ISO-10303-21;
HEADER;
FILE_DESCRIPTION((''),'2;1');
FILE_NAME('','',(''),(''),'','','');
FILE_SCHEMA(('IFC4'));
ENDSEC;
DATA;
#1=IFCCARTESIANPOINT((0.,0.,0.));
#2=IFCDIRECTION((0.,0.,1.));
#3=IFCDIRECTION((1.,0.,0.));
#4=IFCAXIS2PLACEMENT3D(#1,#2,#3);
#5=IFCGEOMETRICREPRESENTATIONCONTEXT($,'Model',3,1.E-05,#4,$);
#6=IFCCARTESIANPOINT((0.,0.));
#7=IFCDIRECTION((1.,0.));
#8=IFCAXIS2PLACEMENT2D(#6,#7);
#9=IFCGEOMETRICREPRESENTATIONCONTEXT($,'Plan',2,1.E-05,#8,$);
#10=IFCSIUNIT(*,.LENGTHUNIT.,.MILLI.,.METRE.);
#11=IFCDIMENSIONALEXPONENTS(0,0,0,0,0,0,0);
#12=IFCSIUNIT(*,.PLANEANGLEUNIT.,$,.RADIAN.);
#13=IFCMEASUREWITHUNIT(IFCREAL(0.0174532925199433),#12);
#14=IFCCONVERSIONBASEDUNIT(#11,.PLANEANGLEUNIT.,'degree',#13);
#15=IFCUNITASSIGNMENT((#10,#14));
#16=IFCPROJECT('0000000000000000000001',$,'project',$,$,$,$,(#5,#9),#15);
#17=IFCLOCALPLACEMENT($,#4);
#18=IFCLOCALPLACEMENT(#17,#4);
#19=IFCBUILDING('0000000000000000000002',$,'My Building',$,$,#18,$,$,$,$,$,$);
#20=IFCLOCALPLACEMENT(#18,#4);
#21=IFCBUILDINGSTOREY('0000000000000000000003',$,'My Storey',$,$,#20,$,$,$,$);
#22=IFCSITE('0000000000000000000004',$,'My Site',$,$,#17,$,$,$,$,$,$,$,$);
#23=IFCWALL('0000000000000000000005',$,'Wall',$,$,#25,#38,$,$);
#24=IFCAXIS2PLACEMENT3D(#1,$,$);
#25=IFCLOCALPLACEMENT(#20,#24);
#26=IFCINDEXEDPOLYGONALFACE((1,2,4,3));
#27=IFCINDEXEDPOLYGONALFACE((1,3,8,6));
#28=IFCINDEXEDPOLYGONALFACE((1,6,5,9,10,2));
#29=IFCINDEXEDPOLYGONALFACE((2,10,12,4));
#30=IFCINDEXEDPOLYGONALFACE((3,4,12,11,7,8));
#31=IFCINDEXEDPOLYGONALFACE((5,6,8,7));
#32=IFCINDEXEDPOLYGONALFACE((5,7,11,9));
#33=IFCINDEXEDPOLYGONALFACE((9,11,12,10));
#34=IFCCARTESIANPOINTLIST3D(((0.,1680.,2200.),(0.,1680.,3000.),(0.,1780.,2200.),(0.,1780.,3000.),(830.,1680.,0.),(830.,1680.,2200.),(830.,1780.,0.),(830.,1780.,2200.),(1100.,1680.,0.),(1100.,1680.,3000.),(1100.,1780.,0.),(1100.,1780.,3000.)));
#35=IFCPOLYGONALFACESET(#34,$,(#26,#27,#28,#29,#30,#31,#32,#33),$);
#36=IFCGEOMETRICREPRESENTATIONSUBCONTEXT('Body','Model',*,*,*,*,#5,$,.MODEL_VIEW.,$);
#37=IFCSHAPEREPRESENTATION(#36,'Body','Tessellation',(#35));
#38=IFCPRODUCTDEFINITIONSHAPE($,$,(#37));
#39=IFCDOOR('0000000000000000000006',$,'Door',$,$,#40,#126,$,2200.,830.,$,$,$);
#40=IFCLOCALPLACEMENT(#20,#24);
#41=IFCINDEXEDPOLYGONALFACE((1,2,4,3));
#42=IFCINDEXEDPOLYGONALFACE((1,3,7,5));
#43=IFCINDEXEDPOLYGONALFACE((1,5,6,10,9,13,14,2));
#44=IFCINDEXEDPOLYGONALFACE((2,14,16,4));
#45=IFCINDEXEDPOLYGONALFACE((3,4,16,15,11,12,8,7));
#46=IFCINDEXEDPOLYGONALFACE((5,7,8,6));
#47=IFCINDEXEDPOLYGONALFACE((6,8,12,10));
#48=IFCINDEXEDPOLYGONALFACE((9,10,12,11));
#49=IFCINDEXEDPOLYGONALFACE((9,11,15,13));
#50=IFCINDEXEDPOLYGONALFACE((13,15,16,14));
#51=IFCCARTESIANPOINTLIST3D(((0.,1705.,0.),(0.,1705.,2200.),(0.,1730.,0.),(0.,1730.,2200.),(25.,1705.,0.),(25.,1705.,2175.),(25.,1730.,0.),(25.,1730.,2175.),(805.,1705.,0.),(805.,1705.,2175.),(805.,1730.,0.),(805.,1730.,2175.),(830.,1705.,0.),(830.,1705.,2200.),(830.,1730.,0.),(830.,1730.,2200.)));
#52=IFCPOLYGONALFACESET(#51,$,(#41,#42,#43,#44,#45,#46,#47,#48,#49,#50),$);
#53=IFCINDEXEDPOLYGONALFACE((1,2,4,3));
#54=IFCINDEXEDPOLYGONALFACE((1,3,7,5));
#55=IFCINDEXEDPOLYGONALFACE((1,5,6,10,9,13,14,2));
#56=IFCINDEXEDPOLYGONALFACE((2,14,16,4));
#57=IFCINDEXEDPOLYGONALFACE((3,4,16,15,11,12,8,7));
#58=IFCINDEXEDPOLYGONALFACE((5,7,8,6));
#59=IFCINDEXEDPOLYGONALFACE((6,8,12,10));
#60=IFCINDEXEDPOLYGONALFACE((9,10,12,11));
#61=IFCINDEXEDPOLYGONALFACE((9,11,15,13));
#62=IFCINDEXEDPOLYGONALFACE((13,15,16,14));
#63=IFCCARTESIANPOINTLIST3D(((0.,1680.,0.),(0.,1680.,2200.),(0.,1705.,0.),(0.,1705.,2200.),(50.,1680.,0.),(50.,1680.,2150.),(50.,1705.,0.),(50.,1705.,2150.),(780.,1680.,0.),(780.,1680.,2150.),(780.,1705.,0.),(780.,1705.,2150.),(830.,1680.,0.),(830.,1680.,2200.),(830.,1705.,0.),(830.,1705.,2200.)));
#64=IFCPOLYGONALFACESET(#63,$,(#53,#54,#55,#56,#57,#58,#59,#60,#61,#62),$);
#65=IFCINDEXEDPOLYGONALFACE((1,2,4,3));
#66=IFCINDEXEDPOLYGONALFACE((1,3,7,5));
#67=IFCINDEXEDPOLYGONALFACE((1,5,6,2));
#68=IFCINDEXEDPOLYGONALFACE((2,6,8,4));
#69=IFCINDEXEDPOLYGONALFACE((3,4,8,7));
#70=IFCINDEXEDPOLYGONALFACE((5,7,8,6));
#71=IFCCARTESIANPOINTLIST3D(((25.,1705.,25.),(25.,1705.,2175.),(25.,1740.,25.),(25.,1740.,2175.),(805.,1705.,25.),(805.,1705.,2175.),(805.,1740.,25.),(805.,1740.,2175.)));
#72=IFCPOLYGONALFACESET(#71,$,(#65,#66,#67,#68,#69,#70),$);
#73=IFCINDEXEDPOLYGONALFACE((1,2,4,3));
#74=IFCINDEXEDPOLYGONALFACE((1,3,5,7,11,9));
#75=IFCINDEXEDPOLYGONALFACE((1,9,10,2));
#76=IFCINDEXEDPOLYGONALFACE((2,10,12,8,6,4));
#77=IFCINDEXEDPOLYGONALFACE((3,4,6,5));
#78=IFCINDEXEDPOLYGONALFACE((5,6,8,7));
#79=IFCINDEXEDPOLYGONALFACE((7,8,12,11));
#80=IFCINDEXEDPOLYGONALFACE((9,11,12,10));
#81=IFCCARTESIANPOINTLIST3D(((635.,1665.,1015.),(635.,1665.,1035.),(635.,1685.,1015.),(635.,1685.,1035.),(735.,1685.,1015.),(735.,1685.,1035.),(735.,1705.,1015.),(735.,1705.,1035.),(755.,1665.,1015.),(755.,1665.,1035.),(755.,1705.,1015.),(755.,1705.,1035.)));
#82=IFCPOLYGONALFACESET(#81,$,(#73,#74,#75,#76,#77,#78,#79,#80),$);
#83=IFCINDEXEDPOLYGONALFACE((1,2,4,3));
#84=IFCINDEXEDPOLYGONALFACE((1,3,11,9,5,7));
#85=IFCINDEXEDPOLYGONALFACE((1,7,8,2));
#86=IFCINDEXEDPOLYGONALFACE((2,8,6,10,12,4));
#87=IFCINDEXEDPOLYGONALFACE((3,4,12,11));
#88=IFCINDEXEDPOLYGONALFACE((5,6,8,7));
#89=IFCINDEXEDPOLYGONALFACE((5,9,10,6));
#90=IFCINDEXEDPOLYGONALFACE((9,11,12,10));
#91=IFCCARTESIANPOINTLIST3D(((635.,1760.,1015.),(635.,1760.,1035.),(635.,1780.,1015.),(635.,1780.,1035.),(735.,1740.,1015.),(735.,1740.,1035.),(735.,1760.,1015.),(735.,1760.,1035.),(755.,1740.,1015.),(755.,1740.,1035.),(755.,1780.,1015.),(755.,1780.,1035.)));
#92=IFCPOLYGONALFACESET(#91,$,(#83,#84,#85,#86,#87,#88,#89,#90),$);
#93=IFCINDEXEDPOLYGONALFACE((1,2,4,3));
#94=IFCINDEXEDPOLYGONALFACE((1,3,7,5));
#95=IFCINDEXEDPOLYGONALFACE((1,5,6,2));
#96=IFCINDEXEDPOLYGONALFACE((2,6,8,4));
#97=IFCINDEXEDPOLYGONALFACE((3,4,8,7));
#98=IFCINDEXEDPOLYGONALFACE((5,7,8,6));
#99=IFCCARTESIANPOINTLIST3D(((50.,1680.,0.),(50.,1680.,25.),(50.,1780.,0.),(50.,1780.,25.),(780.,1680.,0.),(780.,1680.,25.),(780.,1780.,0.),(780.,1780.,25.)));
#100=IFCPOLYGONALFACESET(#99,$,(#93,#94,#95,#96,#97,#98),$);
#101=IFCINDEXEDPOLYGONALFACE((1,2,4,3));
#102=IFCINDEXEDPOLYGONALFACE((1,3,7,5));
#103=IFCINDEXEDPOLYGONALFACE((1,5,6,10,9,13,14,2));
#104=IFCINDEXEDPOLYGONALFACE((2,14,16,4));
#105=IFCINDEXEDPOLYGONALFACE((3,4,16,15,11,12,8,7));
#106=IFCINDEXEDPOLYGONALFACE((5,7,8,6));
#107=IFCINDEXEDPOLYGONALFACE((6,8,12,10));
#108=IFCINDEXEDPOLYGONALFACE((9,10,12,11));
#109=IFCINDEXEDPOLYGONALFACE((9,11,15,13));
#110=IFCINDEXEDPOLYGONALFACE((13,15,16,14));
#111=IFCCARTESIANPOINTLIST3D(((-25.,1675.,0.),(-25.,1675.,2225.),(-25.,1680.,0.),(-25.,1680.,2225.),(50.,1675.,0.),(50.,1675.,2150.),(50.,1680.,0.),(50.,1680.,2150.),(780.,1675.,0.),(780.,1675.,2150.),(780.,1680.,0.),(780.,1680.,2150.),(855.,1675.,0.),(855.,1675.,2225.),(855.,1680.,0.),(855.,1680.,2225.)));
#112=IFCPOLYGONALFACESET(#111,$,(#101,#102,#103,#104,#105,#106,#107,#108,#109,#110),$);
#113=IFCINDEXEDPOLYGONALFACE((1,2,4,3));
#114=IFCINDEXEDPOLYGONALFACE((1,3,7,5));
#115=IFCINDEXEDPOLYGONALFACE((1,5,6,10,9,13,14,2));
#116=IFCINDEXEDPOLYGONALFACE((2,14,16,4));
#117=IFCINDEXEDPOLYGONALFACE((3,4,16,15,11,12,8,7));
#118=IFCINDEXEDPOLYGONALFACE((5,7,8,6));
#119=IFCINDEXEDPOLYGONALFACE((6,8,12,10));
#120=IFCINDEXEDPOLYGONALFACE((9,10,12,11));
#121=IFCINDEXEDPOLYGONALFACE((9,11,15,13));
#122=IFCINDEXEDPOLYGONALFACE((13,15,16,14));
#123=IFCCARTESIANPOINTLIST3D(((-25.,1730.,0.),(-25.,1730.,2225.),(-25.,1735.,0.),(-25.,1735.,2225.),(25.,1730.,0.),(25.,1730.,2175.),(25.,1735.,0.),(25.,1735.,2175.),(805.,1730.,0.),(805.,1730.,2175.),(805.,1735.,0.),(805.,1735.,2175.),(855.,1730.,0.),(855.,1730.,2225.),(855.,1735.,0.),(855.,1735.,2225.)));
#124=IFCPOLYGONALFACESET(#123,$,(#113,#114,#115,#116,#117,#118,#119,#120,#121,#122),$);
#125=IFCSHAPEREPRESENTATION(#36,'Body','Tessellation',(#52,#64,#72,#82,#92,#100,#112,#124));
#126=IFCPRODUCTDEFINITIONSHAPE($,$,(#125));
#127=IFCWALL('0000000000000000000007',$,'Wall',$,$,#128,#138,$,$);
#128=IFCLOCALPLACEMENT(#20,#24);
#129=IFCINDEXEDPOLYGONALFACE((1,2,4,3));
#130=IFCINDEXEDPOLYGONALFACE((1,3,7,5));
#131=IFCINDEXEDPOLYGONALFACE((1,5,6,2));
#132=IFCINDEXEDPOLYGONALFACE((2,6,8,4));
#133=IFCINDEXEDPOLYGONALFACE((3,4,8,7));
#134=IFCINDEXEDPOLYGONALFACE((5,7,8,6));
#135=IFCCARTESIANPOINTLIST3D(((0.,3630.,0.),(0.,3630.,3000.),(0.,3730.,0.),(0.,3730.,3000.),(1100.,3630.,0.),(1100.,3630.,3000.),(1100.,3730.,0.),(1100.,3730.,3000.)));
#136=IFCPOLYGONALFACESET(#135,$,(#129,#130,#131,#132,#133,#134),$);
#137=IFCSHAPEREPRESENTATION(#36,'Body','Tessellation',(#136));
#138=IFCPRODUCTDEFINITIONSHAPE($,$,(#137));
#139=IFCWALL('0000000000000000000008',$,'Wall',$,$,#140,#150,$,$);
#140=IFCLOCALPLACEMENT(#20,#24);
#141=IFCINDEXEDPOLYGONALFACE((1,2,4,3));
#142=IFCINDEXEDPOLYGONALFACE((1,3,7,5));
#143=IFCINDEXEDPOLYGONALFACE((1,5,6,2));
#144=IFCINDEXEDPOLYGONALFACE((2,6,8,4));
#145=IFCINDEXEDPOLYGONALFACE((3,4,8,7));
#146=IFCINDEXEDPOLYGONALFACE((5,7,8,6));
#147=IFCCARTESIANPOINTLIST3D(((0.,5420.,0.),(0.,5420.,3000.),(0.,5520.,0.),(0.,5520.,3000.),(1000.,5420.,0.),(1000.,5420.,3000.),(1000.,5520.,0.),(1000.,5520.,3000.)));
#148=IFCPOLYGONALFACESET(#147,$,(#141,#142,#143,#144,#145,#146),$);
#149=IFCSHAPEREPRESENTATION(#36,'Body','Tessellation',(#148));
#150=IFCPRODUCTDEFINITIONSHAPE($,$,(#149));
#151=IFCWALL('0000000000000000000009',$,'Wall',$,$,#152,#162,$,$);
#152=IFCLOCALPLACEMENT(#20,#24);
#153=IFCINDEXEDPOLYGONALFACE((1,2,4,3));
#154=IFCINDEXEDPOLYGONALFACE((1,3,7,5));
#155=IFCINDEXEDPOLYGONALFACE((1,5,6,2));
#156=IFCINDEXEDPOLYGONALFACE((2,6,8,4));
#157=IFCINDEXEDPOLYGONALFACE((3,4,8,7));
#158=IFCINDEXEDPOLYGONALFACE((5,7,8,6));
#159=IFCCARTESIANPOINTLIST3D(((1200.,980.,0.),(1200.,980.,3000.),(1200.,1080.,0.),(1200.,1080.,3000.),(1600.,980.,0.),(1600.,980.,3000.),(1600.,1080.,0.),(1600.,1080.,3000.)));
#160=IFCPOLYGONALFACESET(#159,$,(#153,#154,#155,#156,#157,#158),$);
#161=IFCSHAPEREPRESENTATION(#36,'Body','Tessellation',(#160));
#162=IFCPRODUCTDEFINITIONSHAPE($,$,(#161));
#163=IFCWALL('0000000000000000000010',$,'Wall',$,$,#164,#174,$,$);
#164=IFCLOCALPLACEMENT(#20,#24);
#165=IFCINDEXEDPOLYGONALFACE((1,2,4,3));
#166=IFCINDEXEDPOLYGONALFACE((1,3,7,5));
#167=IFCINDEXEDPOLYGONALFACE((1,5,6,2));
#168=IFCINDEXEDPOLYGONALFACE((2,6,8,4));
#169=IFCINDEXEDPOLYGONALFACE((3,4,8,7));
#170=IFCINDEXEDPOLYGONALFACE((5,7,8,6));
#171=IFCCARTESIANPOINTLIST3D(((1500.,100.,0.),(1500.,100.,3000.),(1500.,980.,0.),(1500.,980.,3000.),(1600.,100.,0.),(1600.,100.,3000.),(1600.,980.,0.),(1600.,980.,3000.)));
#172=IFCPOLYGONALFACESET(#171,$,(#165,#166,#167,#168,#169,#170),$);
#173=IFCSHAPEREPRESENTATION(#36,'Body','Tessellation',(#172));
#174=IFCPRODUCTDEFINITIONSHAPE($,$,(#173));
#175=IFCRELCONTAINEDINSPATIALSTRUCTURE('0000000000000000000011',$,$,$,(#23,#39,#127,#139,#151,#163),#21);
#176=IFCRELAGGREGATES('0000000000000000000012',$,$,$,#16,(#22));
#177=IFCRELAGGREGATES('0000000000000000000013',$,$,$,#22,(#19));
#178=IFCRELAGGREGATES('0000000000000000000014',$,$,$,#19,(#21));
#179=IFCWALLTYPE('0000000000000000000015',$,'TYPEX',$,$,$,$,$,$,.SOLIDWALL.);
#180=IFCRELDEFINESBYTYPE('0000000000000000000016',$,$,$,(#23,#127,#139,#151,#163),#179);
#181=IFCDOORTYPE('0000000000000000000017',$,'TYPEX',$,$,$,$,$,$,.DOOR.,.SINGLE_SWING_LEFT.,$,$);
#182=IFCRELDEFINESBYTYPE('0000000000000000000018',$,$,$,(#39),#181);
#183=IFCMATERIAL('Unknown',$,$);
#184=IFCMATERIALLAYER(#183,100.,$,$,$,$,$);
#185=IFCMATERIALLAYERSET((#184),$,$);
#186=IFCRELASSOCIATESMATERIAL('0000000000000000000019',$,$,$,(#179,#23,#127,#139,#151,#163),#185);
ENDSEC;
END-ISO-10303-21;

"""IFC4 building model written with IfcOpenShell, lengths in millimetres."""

from ifc_helpers import new_model, entity, si_unit, converted_unit, frame, origin_with_axes, origin_2d_with_axis, place, context, subcontext, project, spatial, line, indexed_curve, outline, extrude, shape, source, transform, mapped, material, layer, layer_set, layer_usage, type_object, type_shapes, element, fill, save


model = new_model("IFC4")

# Units and contexts
model_context = context("Model", 3, precision=1e-05, world=origin_with_axes())
plan_context = context("Plan", 2, precision=1e-05, world=origin_2d_with_axis())
body_context_1 = subcontext(model_context, "Body", "Model", "MODEL_VIEW")
body_context_2 = subcontext(plan_context, "Body", "Plan", "PLAN_VIEW")
ifc_project = project(units=[si_unit("LENGTHUNIT", "METRE", prefix="MILLI"), converted_unit("PLANEANGLEUNIT", "degree", entity("IfcReal", 0.0174532925199433), si_unit("PLANEANGLEUNIT", "RADIAN"), dimensions=[0, 0, 0, 0, 0, 0, 0])], contexts=[model_context, plan_context])

# Site, building, storey
site_placement = place(None, origin_with_axes())
site = spatial("IfcSite", under=ifc_project, at=site_placement, Name="My Site")
building_placement = place(site_placement, origin_with_axes())
building = spatial("IfcBuilding", under=site, at=building_placement, Name="My Building")
storey_placement = place(building_placement, origin_with_axes())
storey = spatial("IfcBuildingStorey", under=building, at=storey_placement, Name="My Storey")

# Shared definitions
ifc_material = material(Name="Unknown")

# Shared definitions
ifc_layer_1 = layer(ifc_material, 100.0)
ifc_layer_set_1 = layer_set([ifc_layer_1])
wall_type = type_object("IfcWallType", Name="TYPEX", PredefinedType="SOLIDWALL", material=ifc_layer_set_1)
shared_shape_1 = source(origin_with_axes(), body_context_1, "Body", "SweptSolid", [
    extrude(outline(indexed_curve([(0.0, 0.0), (830.0, 0.0), (830.0, 2200.0), (0.0, 2200.0)], segments=[line(1, 2, 3, 4, 1)])), frame((0.0, -100.0, 0.0), z_axis=(0.0, -1.0, 0.0), x_axis=(1.0, 0.0, 0.0)), (0.0, 0.0, -1.0), 300.0),
])
door_type = type_object("IfcDoorType", Name="TYPEX", OperationType="SINGLE_SWING_LEFT", PredefinedType="DOOR")
shared_shape_2 = source(origin_with_axes(), body_context_1, "Body", "SweptSolid", [
    extrude(outline(indexed_curve([(0.0, 0.0), (0.0, 2200.0), (830.0, 2200.0), (830.0, 0.0), (805.0, 0.0), (805.0, 2175.0), (25.0, 2175.0), (25.0, 0.0)], segments=[line(1, 2, 3, 4, 5, 6, 7, 8, 1)])), frame((0.0, 25.0, 0.0), z_axis=(0.0, -1.0, 0.0), x_axis=(1.0, 0.0, 0.0)), (0.0, 0.0, -1.0), 25.0),
    extrude(outline(indexed_curve([(0.0, 0.0), (0.0, 2200.0), (830.0, 2200.0), (830.0, 0.0), (780.0, 0.0), (780.0, 2150.0), (50.0, 2150.0), (50.0, 0.0)], segments=[line(1, 2, 3, 4, 5, 6, 7, 8, 1)])), frame((0.0, 0.0, 0.0), z_axis=(0.0, -1.0, 0.0), x_axis=(1.0, 0.0, 0.0)), (0.0, 0.0, -1.0), 25.0),
    extrude(outline(indexed_curve([(0.0, 0.0), (780.0, 0.0), (780.0, 35.0), (0.0, 35.0)], segments=[line(1, 2, 3, 4, 1)])), frame((25.0, 25.0, 25.0), z_axis=(0.0, 0.0, 1.0), x_axis=(1.0, 0.0, 0.0)), (0.0, 0.0, 1.0), 2150.0),
    extrude(outline(indexed_curve([(0.0, 0.0), (0.0, -40.0), (-120.0, -40.0), (-120.0, -20.0), (-20.0, -20.0), (-20.0, 0.0)], segments=[line(1, 2, 3, 4, 5, 6, 1)])), frame((755.0, 25.0, 1015.0), z_axis=(0.0, 0.0, 1.0), x_axis=(1.0, 0.0, 0.0)), (0.0, 0.0, 1.0), 20.0),
    extrude(outline(indexed_curve([(0.0, 0.0), (0.0, 40.0), (-120.0, 40.0), (-120.0, 20.0), (-20.0, 20.0), (-20.0, 0.0)], segments=[line(1, 2, 3, 4, 5, 6, 1)])), frame((755.0, 60.0, 1015.0), z_axis=(0.0, 0.0, 1.0), x_axis=(1.0, 0.0, 0.0)), (0.0, 0.0, 1.0), 20.0),
    extrude(outline(indexed_curve([(0.0, 0.0), (730.0, 0.0), (730.0, 100.0), (0.0, 100.0)], segments=[line(1, 2, 3, 4, 1)])), frame((50.0, 0.0, 0.0), z_axis=(0.0, 0.0, 1.0), x_axis=(1.0, 0.0, 0.0)), (0.0, 0.0, 1.0), 25.0),
    extrude(outline(indexed_curve([(0.0, 0.0), (0.0, 2225.0), (880.0, 2225.0), (880.0, 0.0), (805.0, 0.0), (805.0, 2150.0), (75.0, 2150.0), (75.0, 0.0)], segments=[line(1, 2, 3, 4, 5, 6, 7, 8, 1)])), frame((-25.0, -5.0, 0.0), z_axis=(0.0, -1.0, 0.0), x_axis=(1.0, 0.0, 0.0)), (0.0, 0.0, -1.0), 5.0),
    extrude(outline(indexed_curve([(0.0, 0.0), (0.0, 2225.0), (880.0, 2225.0), (880.0, 0.0), (830.0, 0.0), (830.0, 2175.0), (50.0, 2175.0), (50.0, 0.0)], segments=[line(1, 2, 3, 4, 5, 6, 7, 8, 1)])), frame((-25.0, 50.0, 0.0), z_axis=(0.0, -1.0, 0.0), x_axis=(1.0, 0.0, 0.0)), (0.0, 0.0, -1.0), 5.0),
])
shared_shape_3 = source(origin_with_axes(), body_context_2, "Body", "Curve2D", [
    entity("IfcIndexedPolyCurve", entity("IfcCartesianPointList2D", [[0.0, 0.0], [0.0, 50.0], [25.0, 50.0], [25.0, 25.0], [50.0, 25.0], [50.0, 0.0]]), [entity("IfcLineIndex", [1, 2, 3, 4, 5, 6, 1])]),
    entity("IfcIndexedPolyCurve", entity("IfcCartesianPointList2D", [[830.0, 0.0], [830.0, 50.0], [805.0, 50.0], [805.0, 25.0], [780.0, 25.0], [780.0, 0.0]]), [entity("IfcLineIndex", [1, 2, 3, 4, 5, 6, 1])]),
    entity("IfcTrimmedCurve", entity("IfcEllipse", entity("IfcAxis2Placement2D", entity("IfcCartesianPoint", [60.0, 50.0]), entity("IfcDirection", [1.0, 0.0])), 745.0, 780.0), [entity("IfcCartesianPoint", [805.0, 50.0])], [entity("IfcCartesianPoint", [60.0, 830.0])], True, "CARTESIAN"),
    entity("IfcIndexedPolyCurve", entity("IfcCartesianPointList2D", [[25.0, 50.0], [60.0, 50.0], [60.0, 830.0], [25.0, 830.0]]), [entity("IfcLineIndex", [1, 2, 3, 4, 1])]),
])
type_shapes(door_type, [shared_shape_2, shared_shape_3])

# Wall, opening, door
ifc_layer_usage_1 = layer_usage(ifc_layer_set_1, "AXIS2", "POSITIVE", 0.0)
wall_1_placement = place(storey_placement, frame((0.0, 1680.0, 0.0), z_axis=(0.0, 0.0, 1.0), x_axis=(1.0, -0.000001, 0.0)))
wall_1 = element("IfcWall", 1, at=wall_1_placement, inside=storey, type_object=wall_type, material=ifc_layer_usage_1, Name="Wall", context=body_context_1, shape_type="SweptSolid", body=[
    extrude(outline(indexed_curve([(0.0, 0.0), (0.0, 100.0), (1100.0, 100.0), (1100.0, 0.0), (0.0, 0.0)], self_intersect=False)), origin_with_axes(), (0.0, 0.0, 1.0), 3000.0),
])
opening_1_placement = place(wall_1_placement, frame((0.0, 0.0, 0.0), z_axis=(0.0, 0.0, 1.0), x_axis=(1.0, 0.0, 0.0)))
opening_1 = element("IfcOpeningElement", 2, at=opening_1_placement, cuts=wall_1, PredefinedType="OPENING", context=body_context_1, shape_type="MappedRepresentation", body=[
    mapped(shared_shape_1, transform((0.0, 0.0, 0.0), x_axis=(1.0, 0.0, 0.0), y_axis=(0.0, 1.0, 0.0), z_axis=(0.0, 0.0, 1.0), scale=1.0)),
])
door_1_placement = place(opening_1_placement, origin_with_axes())
door_1 = element("IfcDoor", 3, at=door_1_placement, inside=storey, type_object=door_type, Name="Door", OverallHeight=2200.0, OverallWidth=830.0, shapes=[
    shape(body_context_1, "Body", "MappedRepresentation", [mapped(shared_shape_2, transform((0.0, 0.0, 0.0), x_axis=(1.0, 0.0, 0.0), y_axis=(0.0, 1.0, 0.0), z_axis=(0.0, 0.0, 1.0), scale=1.0))]),
    shape(body_context_2, "Body", "MappedRepresentation", [mapped(shared_shape_3, transform((0.0, 0.0, 0.0), x_axis=(1.0, 0.0, 0.0), y_axis=(0.0, 1.0, 0.0), z_axis=(0.0, 0.0, 1.0), scale=1.0))]),
])
fill(opening_1, door_1)

# Wall
ifc_layer_usage_2 = layer_usage(ifc_layer_set_1, "AXIS2", "POSITIVE", 0.0)
wall_2_placement = place(storey_placement, frame((0.0, 3630.0, 0.0), z_axis=(0.0, 0.0, 1.0), x_axis=(1.0, -0.000001, 0.0)))
element("IfcWall", 4, at=wall_2_placement, inside=storey, type_object=wall_type, material=ifc_layer_usage_2, Name="Wall", context=body_context_1, shape_type="SweptSolid", body=[
    extrude(outline(indexed_curve([(0.0, 0.0), (0.0, 100.0), (1100.0, 100.0), (1100.0, 0.0), (0.0, 0.0)], self_intersect=False)), origin_with_axes(), (0.0, 0.0, 1.0), 3000.0),
])

# Walls
ifc_layer_usage_3 = layer_usage(ifc_layer_set_1, "AXIS2", "POSITIVE", 0.0)
wall_3_placement = place(storey_placement, frame((0.0, 5420.0, 0.0), z_axis=(0.0, 0.0, 1.0), x_axis=(1.0, -0.000001, 0.0)))
element("IfcWall", 5, at=wall_3_placement, inside=storey, type_object=wall_type, material=ifc_layer_usage_3, Name="Wall", context=body_context_1, shape_type="SweptSolid", body=[
    extrude(outline(indexed_curve([(0.0, 0.0), (0.0, 100.0), (1000.0, 100.0), (1000.0, 0.0), (0.0, 0.0)], self_intersect=False)), origin_with_axes(), (0.0, 0.0, 1.0), 3000.0),
])
ifc_layer_usage_4 = layer_usage(ifc_layer_set_1, "AXIS2", "POSITIVE", 0.0)
wall_4_placement = place(storey_placement, frame((1200.0, 980.0, 0.0), z_axis=(0.0, 0.0, 1.0), x_axis=(1.0, -0.000002, 0.0)))
element("IfcWall", 6, at=wall_4_placement, inside=storey, type_object=wall_type, material=ifc_layer_usage_4, Name="Wall", context=body_context_1, shape_type="SweptSolid", body=[
    extrude(outline(indexed_curve([(0.0, 0.0), (0.0, 100.0), (400.0, 100.0), (400.0, 0.0), (0.0, 0.0)], self_intersect=False)), origin_with_axes(), (0.0, 0.0, 1.0), 3000.0),
])
ifc_layer_usage_5 = layer_usage(ifc_layer_set_1, "AXIS2", "POSITIVE", 0.0)
wall_5_placement = place(storey_placement, frame((1500.0, 980.0, 0.0), z_axis=(0.0, 0.0, 1.0), x_axis=(-0.000002, -1.0, 0.0)))
element("IfcWall", 7, at=wall_5_placement, inside=storey, type_object=wall_type, material=ifc_layer_usage_5, Name="Wall", context=body_context_1, shape_type="SweptSolid", body=[
    extrude(outline(indexed_curve([(0.0, 0.0), (0.0, 100.0), (880.0, 100.0), (880.0, 0.0), (0.0, 0.0)], self_intersect=False)), origin_with_axes(), (0.0, 0.0, 1.0), 3000.0),
])

save(model, "model.ifc")
